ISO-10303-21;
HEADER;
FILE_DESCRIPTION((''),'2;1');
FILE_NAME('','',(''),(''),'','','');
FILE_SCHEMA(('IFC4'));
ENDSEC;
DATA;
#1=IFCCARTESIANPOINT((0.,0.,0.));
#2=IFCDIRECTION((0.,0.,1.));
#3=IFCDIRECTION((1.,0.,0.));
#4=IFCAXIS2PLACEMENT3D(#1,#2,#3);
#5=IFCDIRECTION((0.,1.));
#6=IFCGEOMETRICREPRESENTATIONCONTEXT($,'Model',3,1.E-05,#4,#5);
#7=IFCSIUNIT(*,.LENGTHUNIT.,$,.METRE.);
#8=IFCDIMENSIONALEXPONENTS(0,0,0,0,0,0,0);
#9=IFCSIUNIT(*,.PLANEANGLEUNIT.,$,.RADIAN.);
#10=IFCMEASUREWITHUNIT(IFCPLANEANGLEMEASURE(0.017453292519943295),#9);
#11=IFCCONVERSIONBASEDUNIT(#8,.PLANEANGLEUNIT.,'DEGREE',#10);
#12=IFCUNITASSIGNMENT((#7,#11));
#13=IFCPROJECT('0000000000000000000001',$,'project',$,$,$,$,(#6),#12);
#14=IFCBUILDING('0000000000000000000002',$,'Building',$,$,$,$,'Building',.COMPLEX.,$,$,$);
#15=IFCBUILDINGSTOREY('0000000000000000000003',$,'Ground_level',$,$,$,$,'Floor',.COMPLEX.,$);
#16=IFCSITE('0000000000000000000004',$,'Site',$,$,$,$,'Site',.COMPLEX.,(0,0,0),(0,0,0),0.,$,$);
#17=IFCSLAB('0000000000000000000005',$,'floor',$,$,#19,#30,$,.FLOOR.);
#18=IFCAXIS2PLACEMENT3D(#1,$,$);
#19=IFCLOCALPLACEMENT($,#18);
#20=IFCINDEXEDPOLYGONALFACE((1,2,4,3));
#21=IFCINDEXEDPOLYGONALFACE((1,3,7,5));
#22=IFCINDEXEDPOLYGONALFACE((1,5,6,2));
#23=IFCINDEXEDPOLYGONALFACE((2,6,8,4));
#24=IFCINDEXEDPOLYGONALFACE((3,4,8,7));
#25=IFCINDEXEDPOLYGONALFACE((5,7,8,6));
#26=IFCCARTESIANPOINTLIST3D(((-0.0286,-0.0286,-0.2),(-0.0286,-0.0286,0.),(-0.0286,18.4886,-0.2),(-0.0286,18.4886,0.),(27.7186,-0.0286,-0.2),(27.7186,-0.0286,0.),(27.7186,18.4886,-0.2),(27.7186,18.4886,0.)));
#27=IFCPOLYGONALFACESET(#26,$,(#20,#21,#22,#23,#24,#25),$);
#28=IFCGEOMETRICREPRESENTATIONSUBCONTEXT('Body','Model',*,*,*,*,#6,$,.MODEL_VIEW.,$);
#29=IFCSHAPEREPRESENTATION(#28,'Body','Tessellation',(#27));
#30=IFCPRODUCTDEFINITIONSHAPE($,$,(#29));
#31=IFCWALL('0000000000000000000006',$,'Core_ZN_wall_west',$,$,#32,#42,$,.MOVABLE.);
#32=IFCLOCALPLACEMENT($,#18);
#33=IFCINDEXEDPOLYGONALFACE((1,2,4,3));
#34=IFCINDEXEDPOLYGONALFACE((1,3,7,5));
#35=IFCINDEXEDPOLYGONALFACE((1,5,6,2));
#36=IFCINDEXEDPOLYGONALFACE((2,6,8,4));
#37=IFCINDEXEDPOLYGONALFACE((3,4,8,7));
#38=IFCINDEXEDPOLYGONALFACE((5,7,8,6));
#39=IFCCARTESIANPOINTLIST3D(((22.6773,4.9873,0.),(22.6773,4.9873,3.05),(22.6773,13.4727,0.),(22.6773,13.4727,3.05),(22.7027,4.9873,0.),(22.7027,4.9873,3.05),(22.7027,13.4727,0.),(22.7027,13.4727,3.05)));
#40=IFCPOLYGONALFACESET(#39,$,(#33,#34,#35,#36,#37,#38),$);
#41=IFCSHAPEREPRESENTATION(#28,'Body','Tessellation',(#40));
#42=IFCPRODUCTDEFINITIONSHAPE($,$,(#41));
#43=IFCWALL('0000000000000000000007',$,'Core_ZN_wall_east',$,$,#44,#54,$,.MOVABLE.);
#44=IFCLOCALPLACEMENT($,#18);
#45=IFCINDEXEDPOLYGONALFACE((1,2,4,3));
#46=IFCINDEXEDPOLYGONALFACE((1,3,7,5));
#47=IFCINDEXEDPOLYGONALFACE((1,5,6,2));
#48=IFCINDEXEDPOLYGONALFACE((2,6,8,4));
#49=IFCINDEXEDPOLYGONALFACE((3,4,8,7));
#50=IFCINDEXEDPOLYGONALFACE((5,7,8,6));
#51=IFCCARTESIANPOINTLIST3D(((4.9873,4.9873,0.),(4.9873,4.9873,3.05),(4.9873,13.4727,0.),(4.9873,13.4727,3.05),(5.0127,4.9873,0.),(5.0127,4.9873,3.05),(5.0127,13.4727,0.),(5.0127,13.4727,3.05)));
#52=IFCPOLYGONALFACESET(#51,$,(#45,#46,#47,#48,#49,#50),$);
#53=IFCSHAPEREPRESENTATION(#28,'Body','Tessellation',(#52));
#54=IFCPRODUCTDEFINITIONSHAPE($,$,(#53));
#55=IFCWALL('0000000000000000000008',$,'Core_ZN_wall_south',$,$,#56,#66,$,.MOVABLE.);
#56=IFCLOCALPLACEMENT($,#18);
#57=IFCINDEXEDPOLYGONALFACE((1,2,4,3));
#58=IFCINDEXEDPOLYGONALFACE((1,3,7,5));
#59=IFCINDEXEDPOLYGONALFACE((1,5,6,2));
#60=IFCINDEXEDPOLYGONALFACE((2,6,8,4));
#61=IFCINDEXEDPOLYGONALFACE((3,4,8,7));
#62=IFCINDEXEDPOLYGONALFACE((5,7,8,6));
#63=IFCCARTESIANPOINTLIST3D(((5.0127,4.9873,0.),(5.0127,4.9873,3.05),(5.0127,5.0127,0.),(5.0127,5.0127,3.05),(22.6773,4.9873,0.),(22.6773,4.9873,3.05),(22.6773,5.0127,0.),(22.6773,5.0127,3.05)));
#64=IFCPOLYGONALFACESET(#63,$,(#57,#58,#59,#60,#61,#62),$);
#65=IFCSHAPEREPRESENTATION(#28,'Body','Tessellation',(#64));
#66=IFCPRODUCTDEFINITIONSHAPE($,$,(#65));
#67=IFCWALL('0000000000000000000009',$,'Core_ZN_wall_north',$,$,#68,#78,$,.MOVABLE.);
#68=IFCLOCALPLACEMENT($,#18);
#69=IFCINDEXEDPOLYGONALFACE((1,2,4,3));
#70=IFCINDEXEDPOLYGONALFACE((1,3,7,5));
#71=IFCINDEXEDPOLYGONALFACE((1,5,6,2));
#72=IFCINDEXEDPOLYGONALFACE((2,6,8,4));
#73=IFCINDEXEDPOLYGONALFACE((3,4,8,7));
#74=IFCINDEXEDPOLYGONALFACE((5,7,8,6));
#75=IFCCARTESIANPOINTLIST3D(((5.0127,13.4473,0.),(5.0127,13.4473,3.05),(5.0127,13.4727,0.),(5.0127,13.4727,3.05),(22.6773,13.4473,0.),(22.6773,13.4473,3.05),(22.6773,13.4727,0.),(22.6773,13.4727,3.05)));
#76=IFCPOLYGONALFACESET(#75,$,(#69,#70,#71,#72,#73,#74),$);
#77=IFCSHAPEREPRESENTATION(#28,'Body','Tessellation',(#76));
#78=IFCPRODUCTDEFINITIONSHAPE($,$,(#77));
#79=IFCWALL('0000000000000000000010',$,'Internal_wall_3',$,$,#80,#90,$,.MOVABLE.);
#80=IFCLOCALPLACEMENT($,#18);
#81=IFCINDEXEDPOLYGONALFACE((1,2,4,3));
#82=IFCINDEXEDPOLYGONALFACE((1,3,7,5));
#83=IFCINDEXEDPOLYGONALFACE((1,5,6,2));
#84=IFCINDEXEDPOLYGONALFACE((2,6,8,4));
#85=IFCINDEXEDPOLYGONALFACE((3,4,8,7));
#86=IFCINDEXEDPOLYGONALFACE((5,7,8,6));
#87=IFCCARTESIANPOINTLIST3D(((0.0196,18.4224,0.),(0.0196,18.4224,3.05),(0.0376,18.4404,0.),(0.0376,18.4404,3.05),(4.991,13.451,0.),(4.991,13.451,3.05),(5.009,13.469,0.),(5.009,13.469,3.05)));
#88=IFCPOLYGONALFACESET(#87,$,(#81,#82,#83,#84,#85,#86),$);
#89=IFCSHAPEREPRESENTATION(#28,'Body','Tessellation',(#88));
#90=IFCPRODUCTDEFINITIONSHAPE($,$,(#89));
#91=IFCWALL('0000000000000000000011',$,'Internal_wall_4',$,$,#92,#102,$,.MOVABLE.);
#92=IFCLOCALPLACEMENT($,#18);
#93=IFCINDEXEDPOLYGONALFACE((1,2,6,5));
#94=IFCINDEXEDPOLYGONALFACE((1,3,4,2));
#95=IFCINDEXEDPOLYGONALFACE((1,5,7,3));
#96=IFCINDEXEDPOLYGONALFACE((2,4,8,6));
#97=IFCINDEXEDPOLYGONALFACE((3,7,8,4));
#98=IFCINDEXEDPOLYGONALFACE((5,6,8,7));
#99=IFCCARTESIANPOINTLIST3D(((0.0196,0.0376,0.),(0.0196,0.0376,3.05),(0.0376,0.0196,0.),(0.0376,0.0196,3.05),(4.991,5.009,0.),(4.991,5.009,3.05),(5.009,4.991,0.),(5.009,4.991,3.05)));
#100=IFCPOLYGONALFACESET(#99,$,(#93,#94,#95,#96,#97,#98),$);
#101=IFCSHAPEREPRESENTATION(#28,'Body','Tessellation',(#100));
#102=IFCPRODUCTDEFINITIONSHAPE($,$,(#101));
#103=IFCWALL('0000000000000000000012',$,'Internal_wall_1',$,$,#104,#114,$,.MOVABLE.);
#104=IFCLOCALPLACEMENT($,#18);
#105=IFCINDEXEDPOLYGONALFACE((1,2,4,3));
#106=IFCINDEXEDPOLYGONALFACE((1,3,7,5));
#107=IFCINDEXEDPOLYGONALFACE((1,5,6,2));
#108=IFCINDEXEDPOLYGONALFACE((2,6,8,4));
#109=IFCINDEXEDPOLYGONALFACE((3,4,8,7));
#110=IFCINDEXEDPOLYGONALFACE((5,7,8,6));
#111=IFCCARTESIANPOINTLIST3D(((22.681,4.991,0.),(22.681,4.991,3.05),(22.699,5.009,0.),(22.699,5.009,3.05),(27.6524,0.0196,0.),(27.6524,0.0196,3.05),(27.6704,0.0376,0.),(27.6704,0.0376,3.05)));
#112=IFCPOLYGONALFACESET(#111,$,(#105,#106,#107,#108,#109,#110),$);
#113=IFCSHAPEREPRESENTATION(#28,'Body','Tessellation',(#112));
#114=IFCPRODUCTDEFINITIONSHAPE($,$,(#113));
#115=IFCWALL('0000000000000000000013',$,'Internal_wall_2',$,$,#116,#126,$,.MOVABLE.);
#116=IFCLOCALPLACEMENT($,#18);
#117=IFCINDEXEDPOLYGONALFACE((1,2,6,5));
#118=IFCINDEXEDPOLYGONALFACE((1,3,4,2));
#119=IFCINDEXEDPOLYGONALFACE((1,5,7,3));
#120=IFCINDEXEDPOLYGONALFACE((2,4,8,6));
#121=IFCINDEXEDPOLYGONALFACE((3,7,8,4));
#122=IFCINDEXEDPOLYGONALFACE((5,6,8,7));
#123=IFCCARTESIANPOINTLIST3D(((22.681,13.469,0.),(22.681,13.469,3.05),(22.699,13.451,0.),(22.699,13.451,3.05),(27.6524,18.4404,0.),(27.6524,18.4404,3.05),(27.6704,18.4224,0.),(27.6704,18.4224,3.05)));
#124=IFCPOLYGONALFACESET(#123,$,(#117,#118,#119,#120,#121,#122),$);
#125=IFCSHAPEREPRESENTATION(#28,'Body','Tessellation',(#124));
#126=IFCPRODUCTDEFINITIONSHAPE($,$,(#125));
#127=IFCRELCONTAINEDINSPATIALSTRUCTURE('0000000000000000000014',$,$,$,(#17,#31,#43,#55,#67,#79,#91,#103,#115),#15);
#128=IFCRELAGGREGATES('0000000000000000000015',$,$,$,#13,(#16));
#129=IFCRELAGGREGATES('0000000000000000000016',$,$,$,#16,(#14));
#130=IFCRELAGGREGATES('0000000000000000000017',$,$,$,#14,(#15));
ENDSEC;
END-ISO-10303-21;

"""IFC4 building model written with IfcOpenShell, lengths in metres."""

from ifc_helpers import new_model, entity, si_unit, converted_unit, direction, frame, frame_2d, origin_with_axes, origin_2d_with_axis, place, context, subcontext, project, spatial, rectangle, extrude, element, save


model = new_model("IFC4")

# Units and contexts
model_context = context("Model", 3, precision=1e-05, world=origin_with_axes(), true_north=direction((0.0, 1.0)))
body_context = subcontext(model_context, "Body", "Model", "MODEL_VIEW")
ifc_project = project(units=[si_unit("LENGTHUNIT", "METRE"), converted_unit("PLANEANGLEUNIT", "DEGREE", entity("IfcPlaneAngleMeasure", 0.017453292519943295), si_unit("PLANEANGLEUNIT", "RADIAN"), dimensions=[0, 0, 0, 0, 0, 0, 0])], contexts=[model_context])

# Site, building, storey
site = spatial("IfcSite", under=ifc_project, Name="Site", LongName="Site", CompositionType="COMPLEX", RefLatitude=(0, 0, 0), RefLongitude=(0, 0, 0), RefElevation=0.0)
building = spatial("IfcBuilding", under=site, Name="Building", LongName="Building", CompositionType="COMPLEX")
storey = spatial("IfcBuildingStorey", under=building, Name="Ground_level", LongName="Floor", CompositionType="COMPLEX")

# Slab
placement = place(None, origin_with_axes())
element("IfcSlab", 1, at=placement, inside=storey, Name="floor", PredefinedType="FLOOR", context=body_context, shape_type="SweptSolid", body=[
    extrude(rectangle(XDim=27.7472, YDim=18.5172, at=frame_2d((0.0, 0.0), x_axis=(-1.0, 0.0))), frame((13.845, 9.23, 0.0), z_axis=(0.0, 0.0, 1.0), x_axis=(1.0, 0.0, 0.0)), (0.0, 0.0, -1.0), 0.2),
])

# Walls
element("IfcWall", 2, at=placement, inside=storey, Name="Core_ZN_wall_west", PredefinedType="MOVABLE", context=body_context, shape_type="SweptSolid", body=[
    extrude(rectangle(XDim=8.4854, YDim=0.0254, at=frame_2d((0.0, 0.0), x_axis=(0.0, 1.0))), frame((22.69, 9.23, 0.0), z_axis=(0.0, 0.0, 1.0), x_axis=(1.0, 0.0, 0.0)), (0.0, 0.0, 1.0), 3.05),
])
element("IfcWall", 3, at=placement, inside=storey, Name="Core_ZN_wall_east", PredefinedType="MOVABLE", context=body_context, shape_type="SweptSolid", body=[
    extrude(rectangle(XDim=8.4854, YDim=0.0254, at=frame_2d((0.0, 0.0), x_axis=(0.0, -1.0))), frame((5.0, 9.23, 0.0), z_axis=(0.0, 0.0, 1.0), x_axis=(1.0, 0.0, 0.0)), (0.0, 0.0, 1.0), 3.05),
])
element("IfcWall", 4, at=placement, inside=storey, Name="Core_ZN_wall_south", PredefinedType="MOVABLE", context=body_context, shape_type="SweptSolid", body=[
    extrude(rectangle(XDim=17.6646, YDim=0.0254, at=origin_2d_with_axis()), frame((13.845, 5.0, 0.0), z_axis=(0.0, 0.0, 1.0), x_axis=(1.0, 0.0, 0.0)), (0.0, 0.0, 1.0), 3.05),
])
element("IfcWall", 5, at=placement, inside=storey, Name="Core_ZN_wall_north", PredefinedType="MOVABLE", context=body_context, shape_type="SweptSolid", body=[
    extrude(rectangle(XDim=17.6646, YDim=0.0254, at=frame_2d((0.0, 0.0), x_axis=(1.0, 0.0))), frame((13.845, 13.46, 0.0), z_axis=(0.0, 0.0, 1.0), x_axis=(1.0, 0.0, 0.0)), (0.0, 0.0, 1.0), 3.05),
])
element("IfcWall", 6, at=placement, inside=storey, Name="Internal_wall_3", PredefinedType="MOVABLE", context=body_context, shape_type="SweptSolid", body=[
    extrude(rectangle(XDim=7.0306, YDim=0.0254, at=frame_2d((0.0, 0.0), x_axis=(0.707107, -0.707107))), frame((2.5143, 15.9457, 0.0), z_axis=(0.0, 0.0, 1.0), x_axis=(1.0, 0.0, 0.0)), (0.0, 0.0, 1.0), 3.05),
])
element("IfcWall", 7, at=placement, inside=storey, Name="Internal_wall_4", PredefinedType="MOVABLE", context=body_context, shape_type="SweptSolid", body=[
    extrude(rectangle(XDim=7.0306, YDim=0.0254, at=frame_2d((0.0, 0.0), x_axis=(-0.707107, -0.707107))), frame((2.5143, 2.5143, 0.0), z_axis=(0.0, 0.0, 1.0), x_axis=(1.0, 0.0, 0.0)), (0.0, 0.0, 1.0), 3.05),
])
element("IfcWall", 8, at=placement, inside=storey, Name="Internal_wall_1", PredefinedType="MOVABLE", context=body_context, shape_type="SweptSolid", body=[
    extrude(rectangle(XDim=7.0306, YDim=0.0254, at=frame_2d((0.0, 0.0), x_axis=(0.707107, -0.707107))), frame((25.1757, 2.5143, 0.0), z_axis=(0.0, 0.0, 1.0), x_axis=(1.0, 0.0, 0.0)), (0.0, 0.0, 1.0), 3.05),
])
element("IfcWall", 9, at=placement, inside=storey, Name="Internal_wall_2", PredefinedType="MOVABLE", context=body_context, shape_type="SweptSolid", body=[
    extrude(rectangle(XDim=7.0306, YDim=0.0254, at=frame_2d((0.0, 0.0), x_axis=(0.707107, 0.707107))), frame((25.1757, 15.9457, 0.0), z_axis=(0.0, 0.0, 1.0), x_axis=(1.0, 0.0, 0.0)), (0.0, 0.0, 1.0), 3.05),
])

save(model, "model.ifc")
